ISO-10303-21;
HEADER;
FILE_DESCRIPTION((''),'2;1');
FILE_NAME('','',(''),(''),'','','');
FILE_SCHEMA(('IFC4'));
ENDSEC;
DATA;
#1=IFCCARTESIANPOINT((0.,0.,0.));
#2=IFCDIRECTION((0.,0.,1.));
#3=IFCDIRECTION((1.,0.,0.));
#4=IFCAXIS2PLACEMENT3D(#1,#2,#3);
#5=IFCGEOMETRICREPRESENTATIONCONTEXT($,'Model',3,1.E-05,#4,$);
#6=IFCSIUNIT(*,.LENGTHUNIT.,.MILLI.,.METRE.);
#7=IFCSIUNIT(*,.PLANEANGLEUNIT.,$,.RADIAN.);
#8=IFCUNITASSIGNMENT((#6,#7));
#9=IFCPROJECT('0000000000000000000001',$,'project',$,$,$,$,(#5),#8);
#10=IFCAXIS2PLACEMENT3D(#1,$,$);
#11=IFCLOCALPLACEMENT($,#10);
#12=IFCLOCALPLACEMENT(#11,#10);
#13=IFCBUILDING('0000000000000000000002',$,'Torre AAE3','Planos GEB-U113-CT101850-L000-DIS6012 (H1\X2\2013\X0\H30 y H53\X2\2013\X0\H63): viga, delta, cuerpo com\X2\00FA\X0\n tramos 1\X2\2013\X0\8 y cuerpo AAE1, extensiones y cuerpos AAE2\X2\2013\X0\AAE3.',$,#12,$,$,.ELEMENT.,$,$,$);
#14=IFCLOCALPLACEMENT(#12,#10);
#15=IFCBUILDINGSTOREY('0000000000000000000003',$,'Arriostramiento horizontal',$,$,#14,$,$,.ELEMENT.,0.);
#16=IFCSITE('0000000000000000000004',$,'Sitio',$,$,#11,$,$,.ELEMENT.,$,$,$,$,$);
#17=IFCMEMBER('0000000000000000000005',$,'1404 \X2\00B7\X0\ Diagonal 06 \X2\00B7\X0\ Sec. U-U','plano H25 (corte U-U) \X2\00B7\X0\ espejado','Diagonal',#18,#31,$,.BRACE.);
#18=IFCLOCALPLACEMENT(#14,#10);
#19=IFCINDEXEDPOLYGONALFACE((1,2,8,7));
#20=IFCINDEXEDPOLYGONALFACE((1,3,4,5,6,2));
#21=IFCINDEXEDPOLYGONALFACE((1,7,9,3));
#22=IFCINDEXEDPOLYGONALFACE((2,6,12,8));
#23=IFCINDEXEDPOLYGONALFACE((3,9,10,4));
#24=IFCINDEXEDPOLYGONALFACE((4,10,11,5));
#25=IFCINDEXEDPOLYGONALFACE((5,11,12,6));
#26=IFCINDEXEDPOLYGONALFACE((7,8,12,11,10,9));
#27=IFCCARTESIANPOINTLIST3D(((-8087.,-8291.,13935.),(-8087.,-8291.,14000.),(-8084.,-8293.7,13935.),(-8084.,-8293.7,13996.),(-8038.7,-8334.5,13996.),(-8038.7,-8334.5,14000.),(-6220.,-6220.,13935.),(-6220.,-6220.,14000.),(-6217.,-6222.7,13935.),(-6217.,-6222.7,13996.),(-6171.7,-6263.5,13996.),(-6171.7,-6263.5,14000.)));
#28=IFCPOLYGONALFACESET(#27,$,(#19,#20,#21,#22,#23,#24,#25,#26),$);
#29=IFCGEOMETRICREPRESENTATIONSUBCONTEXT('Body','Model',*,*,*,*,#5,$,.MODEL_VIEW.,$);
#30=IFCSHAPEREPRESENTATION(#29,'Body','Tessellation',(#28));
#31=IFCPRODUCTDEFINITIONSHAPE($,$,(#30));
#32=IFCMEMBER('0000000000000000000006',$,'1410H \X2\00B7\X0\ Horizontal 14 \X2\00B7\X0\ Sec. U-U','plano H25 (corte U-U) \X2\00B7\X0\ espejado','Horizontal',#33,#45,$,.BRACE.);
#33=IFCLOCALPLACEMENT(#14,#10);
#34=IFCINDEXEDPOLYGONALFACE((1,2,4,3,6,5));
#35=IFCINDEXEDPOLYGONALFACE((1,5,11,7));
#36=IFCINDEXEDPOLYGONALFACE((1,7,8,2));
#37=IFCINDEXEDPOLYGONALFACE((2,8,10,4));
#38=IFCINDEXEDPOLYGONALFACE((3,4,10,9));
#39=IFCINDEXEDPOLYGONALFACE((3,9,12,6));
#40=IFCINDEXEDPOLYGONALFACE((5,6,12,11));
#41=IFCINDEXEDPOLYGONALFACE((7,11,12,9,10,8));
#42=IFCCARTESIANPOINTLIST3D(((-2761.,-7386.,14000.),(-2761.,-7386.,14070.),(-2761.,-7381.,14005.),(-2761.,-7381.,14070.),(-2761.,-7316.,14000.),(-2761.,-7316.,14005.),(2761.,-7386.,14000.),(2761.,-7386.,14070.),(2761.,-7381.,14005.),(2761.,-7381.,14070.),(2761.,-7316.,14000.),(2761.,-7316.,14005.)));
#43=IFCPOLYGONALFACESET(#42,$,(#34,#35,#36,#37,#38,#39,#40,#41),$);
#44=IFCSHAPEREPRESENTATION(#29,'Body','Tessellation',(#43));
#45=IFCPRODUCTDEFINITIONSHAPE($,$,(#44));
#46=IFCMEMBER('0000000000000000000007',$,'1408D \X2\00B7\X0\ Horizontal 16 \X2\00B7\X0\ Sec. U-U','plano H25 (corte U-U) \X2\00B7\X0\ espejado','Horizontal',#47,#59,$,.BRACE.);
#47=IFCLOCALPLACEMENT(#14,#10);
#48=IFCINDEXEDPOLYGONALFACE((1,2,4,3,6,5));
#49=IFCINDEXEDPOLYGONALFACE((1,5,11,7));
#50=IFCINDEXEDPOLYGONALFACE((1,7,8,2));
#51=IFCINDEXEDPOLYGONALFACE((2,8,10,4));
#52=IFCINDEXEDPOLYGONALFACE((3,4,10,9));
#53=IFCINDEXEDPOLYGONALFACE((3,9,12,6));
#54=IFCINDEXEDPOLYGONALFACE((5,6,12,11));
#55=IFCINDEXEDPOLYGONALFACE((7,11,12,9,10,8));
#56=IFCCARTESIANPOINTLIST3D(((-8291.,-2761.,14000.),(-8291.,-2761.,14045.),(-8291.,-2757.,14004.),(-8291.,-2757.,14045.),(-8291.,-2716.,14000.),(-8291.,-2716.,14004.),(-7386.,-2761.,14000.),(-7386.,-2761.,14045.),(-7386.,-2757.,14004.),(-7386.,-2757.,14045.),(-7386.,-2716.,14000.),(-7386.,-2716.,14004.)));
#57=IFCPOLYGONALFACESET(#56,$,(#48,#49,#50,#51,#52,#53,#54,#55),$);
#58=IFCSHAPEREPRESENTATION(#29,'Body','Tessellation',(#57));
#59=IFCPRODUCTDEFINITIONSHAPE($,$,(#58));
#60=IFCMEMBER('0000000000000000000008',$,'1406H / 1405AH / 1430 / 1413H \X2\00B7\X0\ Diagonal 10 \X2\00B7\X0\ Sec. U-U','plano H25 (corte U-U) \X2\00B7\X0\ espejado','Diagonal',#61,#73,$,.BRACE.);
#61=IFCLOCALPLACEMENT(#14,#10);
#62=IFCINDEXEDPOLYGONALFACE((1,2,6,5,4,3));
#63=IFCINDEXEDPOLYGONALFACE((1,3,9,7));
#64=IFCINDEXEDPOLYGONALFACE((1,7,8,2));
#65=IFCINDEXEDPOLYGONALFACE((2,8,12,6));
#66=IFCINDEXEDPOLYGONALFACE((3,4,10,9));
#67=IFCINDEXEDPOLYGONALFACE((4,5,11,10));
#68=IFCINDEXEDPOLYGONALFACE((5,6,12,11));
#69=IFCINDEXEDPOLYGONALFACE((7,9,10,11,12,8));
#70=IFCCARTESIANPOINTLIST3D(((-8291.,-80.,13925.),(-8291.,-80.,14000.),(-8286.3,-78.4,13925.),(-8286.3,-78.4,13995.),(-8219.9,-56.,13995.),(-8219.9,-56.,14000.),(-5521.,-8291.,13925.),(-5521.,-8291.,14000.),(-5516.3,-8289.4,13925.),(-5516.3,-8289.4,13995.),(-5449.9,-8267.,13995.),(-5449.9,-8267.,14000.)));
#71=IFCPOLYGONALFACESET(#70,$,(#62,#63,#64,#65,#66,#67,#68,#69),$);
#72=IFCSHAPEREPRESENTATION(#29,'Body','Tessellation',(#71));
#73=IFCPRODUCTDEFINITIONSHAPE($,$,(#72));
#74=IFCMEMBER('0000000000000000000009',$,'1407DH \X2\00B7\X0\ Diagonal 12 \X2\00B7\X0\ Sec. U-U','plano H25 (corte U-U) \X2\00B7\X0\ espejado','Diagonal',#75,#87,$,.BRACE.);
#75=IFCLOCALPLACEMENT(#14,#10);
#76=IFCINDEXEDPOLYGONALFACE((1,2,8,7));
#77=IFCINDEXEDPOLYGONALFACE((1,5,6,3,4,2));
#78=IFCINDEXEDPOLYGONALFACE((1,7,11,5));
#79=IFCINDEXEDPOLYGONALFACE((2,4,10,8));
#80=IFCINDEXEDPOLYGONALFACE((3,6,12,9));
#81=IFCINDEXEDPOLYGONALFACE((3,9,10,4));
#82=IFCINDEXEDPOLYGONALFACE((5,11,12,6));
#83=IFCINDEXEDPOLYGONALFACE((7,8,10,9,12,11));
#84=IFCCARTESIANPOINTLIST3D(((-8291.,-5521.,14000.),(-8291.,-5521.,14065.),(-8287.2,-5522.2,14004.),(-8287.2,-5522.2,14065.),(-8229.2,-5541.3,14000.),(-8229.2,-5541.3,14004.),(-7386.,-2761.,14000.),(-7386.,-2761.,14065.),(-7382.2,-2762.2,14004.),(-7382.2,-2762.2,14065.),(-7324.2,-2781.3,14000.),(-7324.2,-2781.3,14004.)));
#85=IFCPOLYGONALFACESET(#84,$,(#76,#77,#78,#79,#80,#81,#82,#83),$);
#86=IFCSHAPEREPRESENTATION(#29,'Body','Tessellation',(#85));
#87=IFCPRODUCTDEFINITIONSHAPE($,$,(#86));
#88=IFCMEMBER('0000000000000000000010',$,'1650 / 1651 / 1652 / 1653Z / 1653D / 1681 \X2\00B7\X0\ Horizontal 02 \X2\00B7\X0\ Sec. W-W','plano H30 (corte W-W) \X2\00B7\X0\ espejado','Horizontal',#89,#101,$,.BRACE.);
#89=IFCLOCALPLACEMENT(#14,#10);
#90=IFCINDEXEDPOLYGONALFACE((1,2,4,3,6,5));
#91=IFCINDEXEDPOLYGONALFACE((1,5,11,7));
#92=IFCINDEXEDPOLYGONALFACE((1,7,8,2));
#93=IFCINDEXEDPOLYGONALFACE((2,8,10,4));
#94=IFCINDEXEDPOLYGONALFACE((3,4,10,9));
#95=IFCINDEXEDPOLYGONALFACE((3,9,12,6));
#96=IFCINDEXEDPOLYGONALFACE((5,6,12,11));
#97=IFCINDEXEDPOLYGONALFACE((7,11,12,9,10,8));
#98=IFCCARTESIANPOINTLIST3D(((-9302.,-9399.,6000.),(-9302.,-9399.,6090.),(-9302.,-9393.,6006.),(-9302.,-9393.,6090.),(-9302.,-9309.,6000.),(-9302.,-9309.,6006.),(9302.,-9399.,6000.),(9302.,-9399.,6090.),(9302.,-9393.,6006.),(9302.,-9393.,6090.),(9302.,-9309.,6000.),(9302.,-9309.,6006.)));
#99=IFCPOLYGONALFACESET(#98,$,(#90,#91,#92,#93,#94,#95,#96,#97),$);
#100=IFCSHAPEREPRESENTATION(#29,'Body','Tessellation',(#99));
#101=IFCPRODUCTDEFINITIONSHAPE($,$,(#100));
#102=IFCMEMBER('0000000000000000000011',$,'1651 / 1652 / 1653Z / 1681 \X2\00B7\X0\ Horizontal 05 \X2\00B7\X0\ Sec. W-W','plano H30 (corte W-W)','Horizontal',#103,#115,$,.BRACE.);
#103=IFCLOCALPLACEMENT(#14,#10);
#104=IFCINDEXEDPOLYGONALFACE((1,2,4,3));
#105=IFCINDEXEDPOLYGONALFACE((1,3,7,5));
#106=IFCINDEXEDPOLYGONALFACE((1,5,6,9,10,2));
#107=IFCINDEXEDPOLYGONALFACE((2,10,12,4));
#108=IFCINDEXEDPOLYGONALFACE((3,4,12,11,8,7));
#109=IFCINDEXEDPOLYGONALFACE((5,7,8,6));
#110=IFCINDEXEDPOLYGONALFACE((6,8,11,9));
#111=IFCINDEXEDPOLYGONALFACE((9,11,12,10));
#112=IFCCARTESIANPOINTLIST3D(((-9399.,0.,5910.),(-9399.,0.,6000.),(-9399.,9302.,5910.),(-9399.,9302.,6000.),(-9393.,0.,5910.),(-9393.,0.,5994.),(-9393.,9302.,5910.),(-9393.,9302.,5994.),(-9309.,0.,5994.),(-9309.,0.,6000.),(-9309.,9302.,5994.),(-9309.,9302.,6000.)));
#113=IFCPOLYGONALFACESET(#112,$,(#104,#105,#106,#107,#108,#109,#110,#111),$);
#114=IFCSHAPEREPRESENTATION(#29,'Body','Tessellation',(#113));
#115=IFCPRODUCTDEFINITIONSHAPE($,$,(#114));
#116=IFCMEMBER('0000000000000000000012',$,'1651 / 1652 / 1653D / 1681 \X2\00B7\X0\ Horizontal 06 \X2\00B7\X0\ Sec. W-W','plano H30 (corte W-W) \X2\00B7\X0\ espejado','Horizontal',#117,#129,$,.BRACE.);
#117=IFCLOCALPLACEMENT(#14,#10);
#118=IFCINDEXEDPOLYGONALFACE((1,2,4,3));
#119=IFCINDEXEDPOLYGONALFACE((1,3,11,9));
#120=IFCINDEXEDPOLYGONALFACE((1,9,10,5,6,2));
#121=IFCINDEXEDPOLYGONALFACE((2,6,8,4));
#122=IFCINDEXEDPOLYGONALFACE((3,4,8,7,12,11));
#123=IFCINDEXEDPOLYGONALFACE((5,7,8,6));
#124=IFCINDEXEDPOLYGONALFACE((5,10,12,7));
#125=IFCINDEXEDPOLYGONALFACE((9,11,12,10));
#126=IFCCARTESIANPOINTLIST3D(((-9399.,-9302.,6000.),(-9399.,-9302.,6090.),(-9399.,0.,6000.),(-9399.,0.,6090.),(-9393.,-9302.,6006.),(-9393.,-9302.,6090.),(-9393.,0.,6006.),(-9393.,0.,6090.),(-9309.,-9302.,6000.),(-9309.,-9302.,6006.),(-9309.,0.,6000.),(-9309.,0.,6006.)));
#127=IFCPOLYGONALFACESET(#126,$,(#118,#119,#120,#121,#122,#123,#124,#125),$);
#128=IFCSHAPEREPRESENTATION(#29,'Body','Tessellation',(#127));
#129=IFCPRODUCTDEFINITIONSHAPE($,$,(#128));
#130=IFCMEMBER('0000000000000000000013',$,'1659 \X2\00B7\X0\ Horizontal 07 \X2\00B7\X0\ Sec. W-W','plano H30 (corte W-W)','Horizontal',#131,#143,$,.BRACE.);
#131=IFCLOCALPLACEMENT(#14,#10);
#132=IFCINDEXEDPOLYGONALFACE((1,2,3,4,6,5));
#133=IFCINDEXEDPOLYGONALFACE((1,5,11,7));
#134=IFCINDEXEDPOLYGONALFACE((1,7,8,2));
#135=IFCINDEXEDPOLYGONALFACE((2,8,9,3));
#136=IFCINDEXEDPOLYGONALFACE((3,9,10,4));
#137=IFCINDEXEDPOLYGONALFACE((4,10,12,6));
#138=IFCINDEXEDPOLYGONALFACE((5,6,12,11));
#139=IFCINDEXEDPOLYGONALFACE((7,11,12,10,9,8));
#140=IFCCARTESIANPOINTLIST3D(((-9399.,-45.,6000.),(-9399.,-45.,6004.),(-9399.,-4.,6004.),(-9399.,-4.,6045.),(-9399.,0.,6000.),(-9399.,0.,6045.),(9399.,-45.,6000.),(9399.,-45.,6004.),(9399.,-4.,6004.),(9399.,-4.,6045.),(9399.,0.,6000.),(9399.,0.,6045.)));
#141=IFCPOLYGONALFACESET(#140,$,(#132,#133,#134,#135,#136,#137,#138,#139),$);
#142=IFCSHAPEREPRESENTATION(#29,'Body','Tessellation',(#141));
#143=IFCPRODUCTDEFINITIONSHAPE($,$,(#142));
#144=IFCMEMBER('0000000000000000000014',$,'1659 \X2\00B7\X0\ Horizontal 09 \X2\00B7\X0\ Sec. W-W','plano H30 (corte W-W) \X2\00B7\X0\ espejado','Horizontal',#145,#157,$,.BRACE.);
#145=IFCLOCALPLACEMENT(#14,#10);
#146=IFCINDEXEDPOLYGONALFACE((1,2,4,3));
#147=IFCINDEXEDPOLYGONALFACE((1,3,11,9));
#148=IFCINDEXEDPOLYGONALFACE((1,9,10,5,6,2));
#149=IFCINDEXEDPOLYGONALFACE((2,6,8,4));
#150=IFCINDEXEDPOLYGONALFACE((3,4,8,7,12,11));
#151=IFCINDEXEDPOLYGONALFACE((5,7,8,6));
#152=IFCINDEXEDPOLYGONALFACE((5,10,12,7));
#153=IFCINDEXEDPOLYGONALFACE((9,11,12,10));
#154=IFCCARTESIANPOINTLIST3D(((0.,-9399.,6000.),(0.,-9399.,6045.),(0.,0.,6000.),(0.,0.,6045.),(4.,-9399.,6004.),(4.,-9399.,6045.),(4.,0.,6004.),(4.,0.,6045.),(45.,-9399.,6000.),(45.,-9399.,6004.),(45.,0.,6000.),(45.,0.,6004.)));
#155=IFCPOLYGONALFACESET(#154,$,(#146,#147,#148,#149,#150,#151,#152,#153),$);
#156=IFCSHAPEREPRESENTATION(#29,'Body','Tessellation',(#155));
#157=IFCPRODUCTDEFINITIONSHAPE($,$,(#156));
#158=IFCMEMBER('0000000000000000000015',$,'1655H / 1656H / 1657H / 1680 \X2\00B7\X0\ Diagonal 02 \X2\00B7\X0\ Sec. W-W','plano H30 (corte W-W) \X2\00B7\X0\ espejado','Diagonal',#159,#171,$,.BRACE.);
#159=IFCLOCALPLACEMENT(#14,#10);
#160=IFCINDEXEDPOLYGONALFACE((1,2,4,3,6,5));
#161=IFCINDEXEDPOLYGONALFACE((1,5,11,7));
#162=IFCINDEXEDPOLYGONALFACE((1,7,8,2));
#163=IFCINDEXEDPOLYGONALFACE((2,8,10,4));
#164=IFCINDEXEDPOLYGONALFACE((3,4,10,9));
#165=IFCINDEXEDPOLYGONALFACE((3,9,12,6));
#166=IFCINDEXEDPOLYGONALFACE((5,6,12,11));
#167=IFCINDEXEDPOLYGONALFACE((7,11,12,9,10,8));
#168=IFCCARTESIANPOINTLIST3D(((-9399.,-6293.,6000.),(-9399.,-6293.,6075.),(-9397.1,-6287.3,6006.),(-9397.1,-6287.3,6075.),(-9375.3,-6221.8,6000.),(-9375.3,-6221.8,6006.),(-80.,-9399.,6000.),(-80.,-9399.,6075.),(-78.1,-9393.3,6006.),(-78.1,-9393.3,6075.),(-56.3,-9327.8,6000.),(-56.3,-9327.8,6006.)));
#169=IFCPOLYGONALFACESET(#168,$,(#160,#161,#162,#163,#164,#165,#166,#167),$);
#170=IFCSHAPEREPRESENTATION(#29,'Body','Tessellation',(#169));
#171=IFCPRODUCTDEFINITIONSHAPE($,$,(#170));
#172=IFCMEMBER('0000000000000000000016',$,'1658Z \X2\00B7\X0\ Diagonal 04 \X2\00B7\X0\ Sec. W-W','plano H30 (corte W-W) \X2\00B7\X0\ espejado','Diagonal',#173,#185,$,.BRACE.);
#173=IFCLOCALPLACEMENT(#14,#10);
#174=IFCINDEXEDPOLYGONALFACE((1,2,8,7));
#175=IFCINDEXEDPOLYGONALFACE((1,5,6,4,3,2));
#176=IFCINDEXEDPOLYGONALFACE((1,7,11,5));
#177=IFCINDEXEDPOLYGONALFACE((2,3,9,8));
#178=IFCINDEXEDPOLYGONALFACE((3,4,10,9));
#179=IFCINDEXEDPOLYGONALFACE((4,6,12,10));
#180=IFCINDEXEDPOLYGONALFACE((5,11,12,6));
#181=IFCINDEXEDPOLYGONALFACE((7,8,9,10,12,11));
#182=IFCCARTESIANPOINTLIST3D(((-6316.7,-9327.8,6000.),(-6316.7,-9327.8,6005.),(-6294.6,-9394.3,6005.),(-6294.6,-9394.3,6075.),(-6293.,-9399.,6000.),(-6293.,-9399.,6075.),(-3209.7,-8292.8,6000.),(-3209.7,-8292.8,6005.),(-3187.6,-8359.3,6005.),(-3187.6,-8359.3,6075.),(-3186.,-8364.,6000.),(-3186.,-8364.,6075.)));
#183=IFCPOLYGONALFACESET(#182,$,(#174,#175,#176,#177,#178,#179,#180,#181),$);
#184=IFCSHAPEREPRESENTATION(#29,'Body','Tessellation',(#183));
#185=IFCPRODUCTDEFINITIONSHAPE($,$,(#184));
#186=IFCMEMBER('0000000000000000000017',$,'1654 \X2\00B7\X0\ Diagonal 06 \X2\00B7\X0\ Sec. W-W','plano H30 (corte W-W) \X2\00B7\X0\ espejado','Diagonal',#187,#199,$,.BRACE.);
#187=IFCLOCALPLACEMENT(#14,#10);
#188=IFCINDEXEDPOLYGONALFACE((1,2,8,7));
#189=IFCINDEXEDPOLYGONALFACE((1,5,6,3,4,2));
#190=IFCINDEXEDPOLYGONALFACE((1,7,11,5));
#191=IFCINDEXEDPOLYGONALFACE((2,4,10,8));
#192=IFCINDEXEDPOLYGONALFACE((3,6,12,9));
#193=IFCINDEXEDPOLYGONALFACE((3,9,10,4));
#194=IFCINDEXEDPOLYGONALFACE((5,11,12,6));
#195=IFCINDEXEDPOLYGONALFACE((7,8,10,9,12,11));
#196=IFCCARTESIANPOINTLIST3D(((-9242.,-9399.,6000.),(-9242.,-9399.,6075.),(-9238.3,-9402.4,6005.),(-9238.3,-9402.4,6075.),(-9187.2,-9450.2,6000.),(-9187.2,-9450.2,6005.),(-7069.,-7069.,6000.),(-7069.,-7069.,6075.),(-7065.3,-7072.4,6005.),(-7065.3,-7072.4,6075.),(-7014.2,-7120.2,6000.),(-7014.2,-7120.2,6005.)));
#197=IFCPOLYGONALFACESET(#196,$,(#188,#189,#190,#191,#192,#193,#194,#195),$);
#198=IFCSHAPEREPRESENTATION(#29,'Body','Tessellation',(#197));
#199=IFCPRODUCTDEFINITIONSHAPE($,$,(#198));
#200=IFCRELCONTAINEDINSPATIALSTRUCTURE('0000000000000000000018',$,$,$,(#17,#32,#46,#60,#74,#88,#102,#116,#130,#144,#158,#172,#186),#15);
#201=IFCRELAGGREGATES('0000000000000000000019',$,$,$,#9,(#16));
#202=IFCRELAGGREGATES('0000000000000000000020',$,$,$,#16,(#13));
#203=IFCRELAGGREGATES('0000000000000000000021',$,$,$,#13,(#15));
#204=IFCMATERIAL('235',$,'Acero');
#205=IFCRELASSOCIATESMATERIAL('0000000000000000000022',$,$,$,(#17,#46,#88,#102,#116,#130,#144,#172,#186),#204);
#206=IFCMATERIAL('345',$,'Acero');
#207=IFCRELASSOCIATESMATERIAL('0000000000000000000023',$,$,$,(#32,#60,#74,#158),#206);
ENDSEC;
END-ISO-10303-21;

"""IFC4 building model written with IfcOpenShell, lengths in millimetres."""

from ifc_helpers import new_model, si_unit, frame, frame_2d, origin, origin_with_axes, place, context, subcontext, project, spatial, l_section, extrude, material, element, save


model = new_model("IFC4")

# Units and contexts
model_context = context("Model", 3, precision=1e-05, world=origin_with_axes())
body_context = subcontext(model_context, "Body", "Model", "MODEL_VIEW")
ifc_project = project(units=[si_unit("LENGTHUNIT", "METRE", prefix="MILLI"), si_unit("PLANEANGLEUNIT", "RADIAN")], contexts=[model_context])

# Site, building, storey
site_placement = place(None, origin())
site = spatial("IfcSite", under=ifc_project, at=site_placement, Name="Sitio", CompositionType="ELEMENT")
building_placement = place(site_placement, origin())
building = spatial("IfcBuilding", under=site, at=building_placement, Name="Torre AAE3", Description="Planos GEB-U113-CT101850-L000-DIS6012 (H1–H30 y H53–H63): viga, delta, cuerpo común tramos 1–8 y cuerpo AAE1, extensiones y cuerpos AAE2–AAE3.", CompositionType="ELEMENT")
storey_placement = place(building_placement, origin())
storey = spatial("IfcBuildingStorey", under=building, at=storey_placement, Name="Arriostramiento horizontal", CompositionType="ELEMENT", Elevation=0.0)

# Members
ifc_material_1 = material(Name="235", Category="Acero")
ifc_material_2 = material(Name="345", Category="Acero")
member_1_placement = place(storey_placement, frame((-8087.0, -8291.0, 14000.0), z_axis=(0.669579, 0.742741, 0.0), x_axis=(0.742741, -0.669579, 0.0)))
element("IfcMember", 1, at=member_1_placement, inside=storey, material=ifc_material_1, Name="1404 · Diagonal 06 · Sec. U-U", Description="plano H25 (corte U-U) · espejado", ObjectType="Diagonal", PredefinedType="BRACE", context=body_context, shape_type="SweptSolid", body=[
    extrude(l_section(Depth=65.0, Width=65.0, Thickness=4.0, at=frame_2d((32.5, 32.5))), None, (0.0, 0.0, 1.0), 2788.3),
])
member_2_placement = place(storey_placement, frame((-2761.0, -7386.0, 14000.0), z_axis=(1.0, 0.0, 0.0), x_axis=(0.0, 1.0, 0.0)))
element("IfcMember", 2, at=member_2_placement, inside=storey, material=ifc_material_2, Name="1410H · Horizontal 14 · Sec. U-U", Description="plano H25 (corte U-U) · espejado", ObjectType="Horizontal", PredefinedType="BRACE", context=body_context, shape_type="SweptSolid", body=[
    extrude(l_section(Depth=70.0, Width=70.0, Thickness=5.0, at=frame_2d((35.0, 35.0))), None, (0.0, 0.0, 1.0), 5522.0),
])
member_3_placement = place(storey_placement, frame((-8291.0, -2761.0, 14000.0), z_axis=(1.0, 0.0, 0.0), x_axis=(0.0, 1.0, 0.0)))
element("IfcMember", 3, at=member_3_placement, inside=storey, material=ifc_material_1, Name="1408D · Horizontal 16 · Sec. U-U", Description="plano H25 (corte U-U) · espejado", ObjectType="Horizontal", PredefinedType="BRACE", context=body_context, shape_type="SweptSolid", body=[
    extrude(l_section(Depth=45.0, Width=45.0, Thickness=4.0, at=frame_2d((22.5, 22.5))), None, (0.0, 0.0, 1.0), 905.0),
])
member_4_placement = place(storey_placement, frame((-5521.0, -8291.0, 14000.0), z_axis=(-0.319653, 0.947535, 0.0), x_axis=(0.947535, 0.319653, 0.0)))
element("IfcMember", 4, at=member_4_placement, inside=storey, material=ifc_material_2, Name="1406H / 1405AH / 1430 / 1413H · Diagonal 10 · Sec. U-U", Description="plano H25 (corte U-U) · espejado", ObjectType="Diagonal", PredefinedType="BRACE", context=body_context, shape_type="SweptSolid", body=[
    extrude(l_section(Depth=75.0, Width=75.0, Thickness=5.0, at=frame_2d((37.5, 37.5))), None, (0.0, 0.0, 1.0), 8665.6),
])
member_5_placement = place(storey_placement, frame((-7386.0, -2761.0, 14000.0), z_axis=(-0.311576, -0.950221, 0.0), x_axis=(0.950221, -0.311576, 0.0)))
element("IfcMember", 5, at=member_5_placement, inside=storey, material=ifc_material_2, Name="1407DH · Diagonal 12 · Sec. U-U", Description="plano H25 (corte U-U) · espejado", ObjectType="Diagonal", PredefinedType="BRACE", context=body_context, shape_type="SweptSolid", body=[
    extrude(l_section(Depth=65.0, Width=65.0, Thickness=4.0, at=frame_2d((32.5, 32.5))), None, (0.0, 0.0, 1.0), 2904.6),
])
member_6_placement = place(storey_placement, frame((-9302.0, -9399.0, 6000.0), z_axis=(1.0, 0.0, 0.0), x_axis=(0.0, 1.0, 0.0)))
element("IfcMember", 6, at=member_6_placement, inside=storey, material=ifc_material_1, Name="1650 / 1651 / 1652 / 1653Z / 1653D / 1681 · Horizontal 02 · Sec. W-W", Description="plano H30 (corte W-W) · espejado", ObjectType="Horizontal", PredefinedType="BRACE", context=body_context, shape_type="SweptSolid", body=[
    extrude(l_section(Depth=90.0, Width=90.0, Thickness=6.0, at=frame_2d((45.0, 45.0))), None, (0.0, 0.0, 1.0), 18604.0),
])
for number, where, z_axis, x_axis, name, description in (
    (7, (-9399.0, 0.0, 6000.0), (0.0, 1.0, 0.0), (1.0, 0.0, 0.0), "1651 / 1652 / 1653Z / 1681 · Horizontal 05 · Sec. W-W", "plano H30 (corte W-W)"),
    (8, (-9399.0, 0.0, 6000.0), (0.0, -1.0, 0.0), (1.0, 0.0, 0.0), "1651 / 1652 / 1653D / 1681 · Horizontal 06 · Sec. W-W", "plano H30 (corte W-W) · espejado"),
):
    element("IfcMember", number, at=place(storey_placement, frame(where, z_axis=z_axis, x_axis=x_axis)), inside=storey, material=ifc_material_1, Name=name, Description=description, ObjectType="Horizontal", PredefinedType="BRACE", context=body_context, shape_type="SweptSolid", body=[
        extrude(l_section(Depth=90.0, Width=90.0, Thickness=6.0, at=frame_2d((45.0, 45.0))), None, (0.0, 0.0, 1.0), 9302.0),
    ])
member_7_placement = place(storey_placement, frame((-9399.0, 0.0, 6000.0), z_axis=(1.0, 0.0, 0.0), x_axis=(0.0, 0.0, 1.0)))
element("IfcMember", 9, at=member_7_placement, inside=storey, material=ifc_material_1, Name="1659 · Horizontal 07 · Sec. W-W", Description="plano H30 (corte W-W)", ObjectType="Horizontal", PredefinedType="BRACE", context=body_context, shape_type="SweptSolid", body=[
    extrude(l_section(Depth=45.0, Width=45.0, Thickness=4.0, at=frame_2d((22.5, 22.5))), None, (0.0, 0.0, 1.0), 18798.0),
])
member_8_placement = place(storey_placement, frame((0.0, -9399.0, 6000.0), z_axis=(0.0, 1.0, 0.0), x_axis=(0.0, 0.0, 1.0)))
element("IfcMember", 10, at=member_8_placement, inside=storey, material=ifc_material_1, Name="1659 · Horizontal 09 · Sec. W-W", Description="plano H30 (corte W-W) · espejado", ObjectType="Horizontal", PredefinedType="BRACE", context=body_context, shape_type="SweptSolid", body=[
    extrude(l_section(Depth=45.0, Width=45.0, Thickness=4.0, at=frame_2d((22.5, 22.5))), None, (0.0, 0.0, 1.0), 9399.0),
])
member_9_placement = place(storey_placement, frame((-9399.0, -6293.0, 6000.0), z_axis=(0.948693, -0.316197, 0.0), x_axis=(0.316197, 0.948693, 0.0)))
element("IfcMember", 11, at=member_9_placement, inside=storey, material=ifc_material_2, Name="1655H / 1656H / 1657H / 1680 · Diagonal 02 · Sec. W-W", Description="plano H30 (corte W-W) · espejado", ObjectType="Diagonal", PredefinedType="BRACE", context=body_context, shape_type="SweptSolid", body=[
    extrude(l_section(Depth=75.0, Width=75.0, Thickness=6.0, at=frame_2d((37.5, 37.5))), None, (0.0, 0.0, 1.0), 9823.0),
])
member_10_placement = place(storey_placement, frame((-6293.0, -9399.0, 6000.0), z_axis=(0.948744, 0.316045, 0.0), x_axis=(-0.316045, 0.948744, 0.0)))
element("IfcMember", 12, at=member_10_placement, inside=storey, material=ifc_material_1, Name="1658Z · Diagonal 04 · Sec. W-W", Description="plano H30 (corte W-W) · espejado", ObjectType="Diagonal", PredefinedType="BRACE", context=body_context, shape_type="SweptSolid", body=[
    extrude(l_section(Depth=75.0, Width=75.0, Thickness=5.0, at=frame_2d((37.5, 37.5))), None, (0.0, 0.0, 1.0), 3274.9),
])
member_11_placement = place(storey_placement, frame((-7069.0, -7069.0, 6000.0), z_axis=(-0.682039, -0.731316, 0.0), x_axis=(0.731316, -0.682039, 0.0)))
element("IfcMember", 13, at=member_11_placement, inside=storey, material=ifc_material_1, Name="1654 · Diagonal 06 · Sec. W-W", Description="plano H30 (corte W-W) · espejado", ObjectType="Diagonal", PredefinedType="BRACE", context=body_context, shape_type="SweptSolid", body=[
    extrude(l_section(Depth=75.0, Width=75.0, Thickness=5.0, at=frame_2d((37.5, 37.5))), None, (0.0, 0.0, 1.0), 3186.0),
])

save(model, "model.ifc")
